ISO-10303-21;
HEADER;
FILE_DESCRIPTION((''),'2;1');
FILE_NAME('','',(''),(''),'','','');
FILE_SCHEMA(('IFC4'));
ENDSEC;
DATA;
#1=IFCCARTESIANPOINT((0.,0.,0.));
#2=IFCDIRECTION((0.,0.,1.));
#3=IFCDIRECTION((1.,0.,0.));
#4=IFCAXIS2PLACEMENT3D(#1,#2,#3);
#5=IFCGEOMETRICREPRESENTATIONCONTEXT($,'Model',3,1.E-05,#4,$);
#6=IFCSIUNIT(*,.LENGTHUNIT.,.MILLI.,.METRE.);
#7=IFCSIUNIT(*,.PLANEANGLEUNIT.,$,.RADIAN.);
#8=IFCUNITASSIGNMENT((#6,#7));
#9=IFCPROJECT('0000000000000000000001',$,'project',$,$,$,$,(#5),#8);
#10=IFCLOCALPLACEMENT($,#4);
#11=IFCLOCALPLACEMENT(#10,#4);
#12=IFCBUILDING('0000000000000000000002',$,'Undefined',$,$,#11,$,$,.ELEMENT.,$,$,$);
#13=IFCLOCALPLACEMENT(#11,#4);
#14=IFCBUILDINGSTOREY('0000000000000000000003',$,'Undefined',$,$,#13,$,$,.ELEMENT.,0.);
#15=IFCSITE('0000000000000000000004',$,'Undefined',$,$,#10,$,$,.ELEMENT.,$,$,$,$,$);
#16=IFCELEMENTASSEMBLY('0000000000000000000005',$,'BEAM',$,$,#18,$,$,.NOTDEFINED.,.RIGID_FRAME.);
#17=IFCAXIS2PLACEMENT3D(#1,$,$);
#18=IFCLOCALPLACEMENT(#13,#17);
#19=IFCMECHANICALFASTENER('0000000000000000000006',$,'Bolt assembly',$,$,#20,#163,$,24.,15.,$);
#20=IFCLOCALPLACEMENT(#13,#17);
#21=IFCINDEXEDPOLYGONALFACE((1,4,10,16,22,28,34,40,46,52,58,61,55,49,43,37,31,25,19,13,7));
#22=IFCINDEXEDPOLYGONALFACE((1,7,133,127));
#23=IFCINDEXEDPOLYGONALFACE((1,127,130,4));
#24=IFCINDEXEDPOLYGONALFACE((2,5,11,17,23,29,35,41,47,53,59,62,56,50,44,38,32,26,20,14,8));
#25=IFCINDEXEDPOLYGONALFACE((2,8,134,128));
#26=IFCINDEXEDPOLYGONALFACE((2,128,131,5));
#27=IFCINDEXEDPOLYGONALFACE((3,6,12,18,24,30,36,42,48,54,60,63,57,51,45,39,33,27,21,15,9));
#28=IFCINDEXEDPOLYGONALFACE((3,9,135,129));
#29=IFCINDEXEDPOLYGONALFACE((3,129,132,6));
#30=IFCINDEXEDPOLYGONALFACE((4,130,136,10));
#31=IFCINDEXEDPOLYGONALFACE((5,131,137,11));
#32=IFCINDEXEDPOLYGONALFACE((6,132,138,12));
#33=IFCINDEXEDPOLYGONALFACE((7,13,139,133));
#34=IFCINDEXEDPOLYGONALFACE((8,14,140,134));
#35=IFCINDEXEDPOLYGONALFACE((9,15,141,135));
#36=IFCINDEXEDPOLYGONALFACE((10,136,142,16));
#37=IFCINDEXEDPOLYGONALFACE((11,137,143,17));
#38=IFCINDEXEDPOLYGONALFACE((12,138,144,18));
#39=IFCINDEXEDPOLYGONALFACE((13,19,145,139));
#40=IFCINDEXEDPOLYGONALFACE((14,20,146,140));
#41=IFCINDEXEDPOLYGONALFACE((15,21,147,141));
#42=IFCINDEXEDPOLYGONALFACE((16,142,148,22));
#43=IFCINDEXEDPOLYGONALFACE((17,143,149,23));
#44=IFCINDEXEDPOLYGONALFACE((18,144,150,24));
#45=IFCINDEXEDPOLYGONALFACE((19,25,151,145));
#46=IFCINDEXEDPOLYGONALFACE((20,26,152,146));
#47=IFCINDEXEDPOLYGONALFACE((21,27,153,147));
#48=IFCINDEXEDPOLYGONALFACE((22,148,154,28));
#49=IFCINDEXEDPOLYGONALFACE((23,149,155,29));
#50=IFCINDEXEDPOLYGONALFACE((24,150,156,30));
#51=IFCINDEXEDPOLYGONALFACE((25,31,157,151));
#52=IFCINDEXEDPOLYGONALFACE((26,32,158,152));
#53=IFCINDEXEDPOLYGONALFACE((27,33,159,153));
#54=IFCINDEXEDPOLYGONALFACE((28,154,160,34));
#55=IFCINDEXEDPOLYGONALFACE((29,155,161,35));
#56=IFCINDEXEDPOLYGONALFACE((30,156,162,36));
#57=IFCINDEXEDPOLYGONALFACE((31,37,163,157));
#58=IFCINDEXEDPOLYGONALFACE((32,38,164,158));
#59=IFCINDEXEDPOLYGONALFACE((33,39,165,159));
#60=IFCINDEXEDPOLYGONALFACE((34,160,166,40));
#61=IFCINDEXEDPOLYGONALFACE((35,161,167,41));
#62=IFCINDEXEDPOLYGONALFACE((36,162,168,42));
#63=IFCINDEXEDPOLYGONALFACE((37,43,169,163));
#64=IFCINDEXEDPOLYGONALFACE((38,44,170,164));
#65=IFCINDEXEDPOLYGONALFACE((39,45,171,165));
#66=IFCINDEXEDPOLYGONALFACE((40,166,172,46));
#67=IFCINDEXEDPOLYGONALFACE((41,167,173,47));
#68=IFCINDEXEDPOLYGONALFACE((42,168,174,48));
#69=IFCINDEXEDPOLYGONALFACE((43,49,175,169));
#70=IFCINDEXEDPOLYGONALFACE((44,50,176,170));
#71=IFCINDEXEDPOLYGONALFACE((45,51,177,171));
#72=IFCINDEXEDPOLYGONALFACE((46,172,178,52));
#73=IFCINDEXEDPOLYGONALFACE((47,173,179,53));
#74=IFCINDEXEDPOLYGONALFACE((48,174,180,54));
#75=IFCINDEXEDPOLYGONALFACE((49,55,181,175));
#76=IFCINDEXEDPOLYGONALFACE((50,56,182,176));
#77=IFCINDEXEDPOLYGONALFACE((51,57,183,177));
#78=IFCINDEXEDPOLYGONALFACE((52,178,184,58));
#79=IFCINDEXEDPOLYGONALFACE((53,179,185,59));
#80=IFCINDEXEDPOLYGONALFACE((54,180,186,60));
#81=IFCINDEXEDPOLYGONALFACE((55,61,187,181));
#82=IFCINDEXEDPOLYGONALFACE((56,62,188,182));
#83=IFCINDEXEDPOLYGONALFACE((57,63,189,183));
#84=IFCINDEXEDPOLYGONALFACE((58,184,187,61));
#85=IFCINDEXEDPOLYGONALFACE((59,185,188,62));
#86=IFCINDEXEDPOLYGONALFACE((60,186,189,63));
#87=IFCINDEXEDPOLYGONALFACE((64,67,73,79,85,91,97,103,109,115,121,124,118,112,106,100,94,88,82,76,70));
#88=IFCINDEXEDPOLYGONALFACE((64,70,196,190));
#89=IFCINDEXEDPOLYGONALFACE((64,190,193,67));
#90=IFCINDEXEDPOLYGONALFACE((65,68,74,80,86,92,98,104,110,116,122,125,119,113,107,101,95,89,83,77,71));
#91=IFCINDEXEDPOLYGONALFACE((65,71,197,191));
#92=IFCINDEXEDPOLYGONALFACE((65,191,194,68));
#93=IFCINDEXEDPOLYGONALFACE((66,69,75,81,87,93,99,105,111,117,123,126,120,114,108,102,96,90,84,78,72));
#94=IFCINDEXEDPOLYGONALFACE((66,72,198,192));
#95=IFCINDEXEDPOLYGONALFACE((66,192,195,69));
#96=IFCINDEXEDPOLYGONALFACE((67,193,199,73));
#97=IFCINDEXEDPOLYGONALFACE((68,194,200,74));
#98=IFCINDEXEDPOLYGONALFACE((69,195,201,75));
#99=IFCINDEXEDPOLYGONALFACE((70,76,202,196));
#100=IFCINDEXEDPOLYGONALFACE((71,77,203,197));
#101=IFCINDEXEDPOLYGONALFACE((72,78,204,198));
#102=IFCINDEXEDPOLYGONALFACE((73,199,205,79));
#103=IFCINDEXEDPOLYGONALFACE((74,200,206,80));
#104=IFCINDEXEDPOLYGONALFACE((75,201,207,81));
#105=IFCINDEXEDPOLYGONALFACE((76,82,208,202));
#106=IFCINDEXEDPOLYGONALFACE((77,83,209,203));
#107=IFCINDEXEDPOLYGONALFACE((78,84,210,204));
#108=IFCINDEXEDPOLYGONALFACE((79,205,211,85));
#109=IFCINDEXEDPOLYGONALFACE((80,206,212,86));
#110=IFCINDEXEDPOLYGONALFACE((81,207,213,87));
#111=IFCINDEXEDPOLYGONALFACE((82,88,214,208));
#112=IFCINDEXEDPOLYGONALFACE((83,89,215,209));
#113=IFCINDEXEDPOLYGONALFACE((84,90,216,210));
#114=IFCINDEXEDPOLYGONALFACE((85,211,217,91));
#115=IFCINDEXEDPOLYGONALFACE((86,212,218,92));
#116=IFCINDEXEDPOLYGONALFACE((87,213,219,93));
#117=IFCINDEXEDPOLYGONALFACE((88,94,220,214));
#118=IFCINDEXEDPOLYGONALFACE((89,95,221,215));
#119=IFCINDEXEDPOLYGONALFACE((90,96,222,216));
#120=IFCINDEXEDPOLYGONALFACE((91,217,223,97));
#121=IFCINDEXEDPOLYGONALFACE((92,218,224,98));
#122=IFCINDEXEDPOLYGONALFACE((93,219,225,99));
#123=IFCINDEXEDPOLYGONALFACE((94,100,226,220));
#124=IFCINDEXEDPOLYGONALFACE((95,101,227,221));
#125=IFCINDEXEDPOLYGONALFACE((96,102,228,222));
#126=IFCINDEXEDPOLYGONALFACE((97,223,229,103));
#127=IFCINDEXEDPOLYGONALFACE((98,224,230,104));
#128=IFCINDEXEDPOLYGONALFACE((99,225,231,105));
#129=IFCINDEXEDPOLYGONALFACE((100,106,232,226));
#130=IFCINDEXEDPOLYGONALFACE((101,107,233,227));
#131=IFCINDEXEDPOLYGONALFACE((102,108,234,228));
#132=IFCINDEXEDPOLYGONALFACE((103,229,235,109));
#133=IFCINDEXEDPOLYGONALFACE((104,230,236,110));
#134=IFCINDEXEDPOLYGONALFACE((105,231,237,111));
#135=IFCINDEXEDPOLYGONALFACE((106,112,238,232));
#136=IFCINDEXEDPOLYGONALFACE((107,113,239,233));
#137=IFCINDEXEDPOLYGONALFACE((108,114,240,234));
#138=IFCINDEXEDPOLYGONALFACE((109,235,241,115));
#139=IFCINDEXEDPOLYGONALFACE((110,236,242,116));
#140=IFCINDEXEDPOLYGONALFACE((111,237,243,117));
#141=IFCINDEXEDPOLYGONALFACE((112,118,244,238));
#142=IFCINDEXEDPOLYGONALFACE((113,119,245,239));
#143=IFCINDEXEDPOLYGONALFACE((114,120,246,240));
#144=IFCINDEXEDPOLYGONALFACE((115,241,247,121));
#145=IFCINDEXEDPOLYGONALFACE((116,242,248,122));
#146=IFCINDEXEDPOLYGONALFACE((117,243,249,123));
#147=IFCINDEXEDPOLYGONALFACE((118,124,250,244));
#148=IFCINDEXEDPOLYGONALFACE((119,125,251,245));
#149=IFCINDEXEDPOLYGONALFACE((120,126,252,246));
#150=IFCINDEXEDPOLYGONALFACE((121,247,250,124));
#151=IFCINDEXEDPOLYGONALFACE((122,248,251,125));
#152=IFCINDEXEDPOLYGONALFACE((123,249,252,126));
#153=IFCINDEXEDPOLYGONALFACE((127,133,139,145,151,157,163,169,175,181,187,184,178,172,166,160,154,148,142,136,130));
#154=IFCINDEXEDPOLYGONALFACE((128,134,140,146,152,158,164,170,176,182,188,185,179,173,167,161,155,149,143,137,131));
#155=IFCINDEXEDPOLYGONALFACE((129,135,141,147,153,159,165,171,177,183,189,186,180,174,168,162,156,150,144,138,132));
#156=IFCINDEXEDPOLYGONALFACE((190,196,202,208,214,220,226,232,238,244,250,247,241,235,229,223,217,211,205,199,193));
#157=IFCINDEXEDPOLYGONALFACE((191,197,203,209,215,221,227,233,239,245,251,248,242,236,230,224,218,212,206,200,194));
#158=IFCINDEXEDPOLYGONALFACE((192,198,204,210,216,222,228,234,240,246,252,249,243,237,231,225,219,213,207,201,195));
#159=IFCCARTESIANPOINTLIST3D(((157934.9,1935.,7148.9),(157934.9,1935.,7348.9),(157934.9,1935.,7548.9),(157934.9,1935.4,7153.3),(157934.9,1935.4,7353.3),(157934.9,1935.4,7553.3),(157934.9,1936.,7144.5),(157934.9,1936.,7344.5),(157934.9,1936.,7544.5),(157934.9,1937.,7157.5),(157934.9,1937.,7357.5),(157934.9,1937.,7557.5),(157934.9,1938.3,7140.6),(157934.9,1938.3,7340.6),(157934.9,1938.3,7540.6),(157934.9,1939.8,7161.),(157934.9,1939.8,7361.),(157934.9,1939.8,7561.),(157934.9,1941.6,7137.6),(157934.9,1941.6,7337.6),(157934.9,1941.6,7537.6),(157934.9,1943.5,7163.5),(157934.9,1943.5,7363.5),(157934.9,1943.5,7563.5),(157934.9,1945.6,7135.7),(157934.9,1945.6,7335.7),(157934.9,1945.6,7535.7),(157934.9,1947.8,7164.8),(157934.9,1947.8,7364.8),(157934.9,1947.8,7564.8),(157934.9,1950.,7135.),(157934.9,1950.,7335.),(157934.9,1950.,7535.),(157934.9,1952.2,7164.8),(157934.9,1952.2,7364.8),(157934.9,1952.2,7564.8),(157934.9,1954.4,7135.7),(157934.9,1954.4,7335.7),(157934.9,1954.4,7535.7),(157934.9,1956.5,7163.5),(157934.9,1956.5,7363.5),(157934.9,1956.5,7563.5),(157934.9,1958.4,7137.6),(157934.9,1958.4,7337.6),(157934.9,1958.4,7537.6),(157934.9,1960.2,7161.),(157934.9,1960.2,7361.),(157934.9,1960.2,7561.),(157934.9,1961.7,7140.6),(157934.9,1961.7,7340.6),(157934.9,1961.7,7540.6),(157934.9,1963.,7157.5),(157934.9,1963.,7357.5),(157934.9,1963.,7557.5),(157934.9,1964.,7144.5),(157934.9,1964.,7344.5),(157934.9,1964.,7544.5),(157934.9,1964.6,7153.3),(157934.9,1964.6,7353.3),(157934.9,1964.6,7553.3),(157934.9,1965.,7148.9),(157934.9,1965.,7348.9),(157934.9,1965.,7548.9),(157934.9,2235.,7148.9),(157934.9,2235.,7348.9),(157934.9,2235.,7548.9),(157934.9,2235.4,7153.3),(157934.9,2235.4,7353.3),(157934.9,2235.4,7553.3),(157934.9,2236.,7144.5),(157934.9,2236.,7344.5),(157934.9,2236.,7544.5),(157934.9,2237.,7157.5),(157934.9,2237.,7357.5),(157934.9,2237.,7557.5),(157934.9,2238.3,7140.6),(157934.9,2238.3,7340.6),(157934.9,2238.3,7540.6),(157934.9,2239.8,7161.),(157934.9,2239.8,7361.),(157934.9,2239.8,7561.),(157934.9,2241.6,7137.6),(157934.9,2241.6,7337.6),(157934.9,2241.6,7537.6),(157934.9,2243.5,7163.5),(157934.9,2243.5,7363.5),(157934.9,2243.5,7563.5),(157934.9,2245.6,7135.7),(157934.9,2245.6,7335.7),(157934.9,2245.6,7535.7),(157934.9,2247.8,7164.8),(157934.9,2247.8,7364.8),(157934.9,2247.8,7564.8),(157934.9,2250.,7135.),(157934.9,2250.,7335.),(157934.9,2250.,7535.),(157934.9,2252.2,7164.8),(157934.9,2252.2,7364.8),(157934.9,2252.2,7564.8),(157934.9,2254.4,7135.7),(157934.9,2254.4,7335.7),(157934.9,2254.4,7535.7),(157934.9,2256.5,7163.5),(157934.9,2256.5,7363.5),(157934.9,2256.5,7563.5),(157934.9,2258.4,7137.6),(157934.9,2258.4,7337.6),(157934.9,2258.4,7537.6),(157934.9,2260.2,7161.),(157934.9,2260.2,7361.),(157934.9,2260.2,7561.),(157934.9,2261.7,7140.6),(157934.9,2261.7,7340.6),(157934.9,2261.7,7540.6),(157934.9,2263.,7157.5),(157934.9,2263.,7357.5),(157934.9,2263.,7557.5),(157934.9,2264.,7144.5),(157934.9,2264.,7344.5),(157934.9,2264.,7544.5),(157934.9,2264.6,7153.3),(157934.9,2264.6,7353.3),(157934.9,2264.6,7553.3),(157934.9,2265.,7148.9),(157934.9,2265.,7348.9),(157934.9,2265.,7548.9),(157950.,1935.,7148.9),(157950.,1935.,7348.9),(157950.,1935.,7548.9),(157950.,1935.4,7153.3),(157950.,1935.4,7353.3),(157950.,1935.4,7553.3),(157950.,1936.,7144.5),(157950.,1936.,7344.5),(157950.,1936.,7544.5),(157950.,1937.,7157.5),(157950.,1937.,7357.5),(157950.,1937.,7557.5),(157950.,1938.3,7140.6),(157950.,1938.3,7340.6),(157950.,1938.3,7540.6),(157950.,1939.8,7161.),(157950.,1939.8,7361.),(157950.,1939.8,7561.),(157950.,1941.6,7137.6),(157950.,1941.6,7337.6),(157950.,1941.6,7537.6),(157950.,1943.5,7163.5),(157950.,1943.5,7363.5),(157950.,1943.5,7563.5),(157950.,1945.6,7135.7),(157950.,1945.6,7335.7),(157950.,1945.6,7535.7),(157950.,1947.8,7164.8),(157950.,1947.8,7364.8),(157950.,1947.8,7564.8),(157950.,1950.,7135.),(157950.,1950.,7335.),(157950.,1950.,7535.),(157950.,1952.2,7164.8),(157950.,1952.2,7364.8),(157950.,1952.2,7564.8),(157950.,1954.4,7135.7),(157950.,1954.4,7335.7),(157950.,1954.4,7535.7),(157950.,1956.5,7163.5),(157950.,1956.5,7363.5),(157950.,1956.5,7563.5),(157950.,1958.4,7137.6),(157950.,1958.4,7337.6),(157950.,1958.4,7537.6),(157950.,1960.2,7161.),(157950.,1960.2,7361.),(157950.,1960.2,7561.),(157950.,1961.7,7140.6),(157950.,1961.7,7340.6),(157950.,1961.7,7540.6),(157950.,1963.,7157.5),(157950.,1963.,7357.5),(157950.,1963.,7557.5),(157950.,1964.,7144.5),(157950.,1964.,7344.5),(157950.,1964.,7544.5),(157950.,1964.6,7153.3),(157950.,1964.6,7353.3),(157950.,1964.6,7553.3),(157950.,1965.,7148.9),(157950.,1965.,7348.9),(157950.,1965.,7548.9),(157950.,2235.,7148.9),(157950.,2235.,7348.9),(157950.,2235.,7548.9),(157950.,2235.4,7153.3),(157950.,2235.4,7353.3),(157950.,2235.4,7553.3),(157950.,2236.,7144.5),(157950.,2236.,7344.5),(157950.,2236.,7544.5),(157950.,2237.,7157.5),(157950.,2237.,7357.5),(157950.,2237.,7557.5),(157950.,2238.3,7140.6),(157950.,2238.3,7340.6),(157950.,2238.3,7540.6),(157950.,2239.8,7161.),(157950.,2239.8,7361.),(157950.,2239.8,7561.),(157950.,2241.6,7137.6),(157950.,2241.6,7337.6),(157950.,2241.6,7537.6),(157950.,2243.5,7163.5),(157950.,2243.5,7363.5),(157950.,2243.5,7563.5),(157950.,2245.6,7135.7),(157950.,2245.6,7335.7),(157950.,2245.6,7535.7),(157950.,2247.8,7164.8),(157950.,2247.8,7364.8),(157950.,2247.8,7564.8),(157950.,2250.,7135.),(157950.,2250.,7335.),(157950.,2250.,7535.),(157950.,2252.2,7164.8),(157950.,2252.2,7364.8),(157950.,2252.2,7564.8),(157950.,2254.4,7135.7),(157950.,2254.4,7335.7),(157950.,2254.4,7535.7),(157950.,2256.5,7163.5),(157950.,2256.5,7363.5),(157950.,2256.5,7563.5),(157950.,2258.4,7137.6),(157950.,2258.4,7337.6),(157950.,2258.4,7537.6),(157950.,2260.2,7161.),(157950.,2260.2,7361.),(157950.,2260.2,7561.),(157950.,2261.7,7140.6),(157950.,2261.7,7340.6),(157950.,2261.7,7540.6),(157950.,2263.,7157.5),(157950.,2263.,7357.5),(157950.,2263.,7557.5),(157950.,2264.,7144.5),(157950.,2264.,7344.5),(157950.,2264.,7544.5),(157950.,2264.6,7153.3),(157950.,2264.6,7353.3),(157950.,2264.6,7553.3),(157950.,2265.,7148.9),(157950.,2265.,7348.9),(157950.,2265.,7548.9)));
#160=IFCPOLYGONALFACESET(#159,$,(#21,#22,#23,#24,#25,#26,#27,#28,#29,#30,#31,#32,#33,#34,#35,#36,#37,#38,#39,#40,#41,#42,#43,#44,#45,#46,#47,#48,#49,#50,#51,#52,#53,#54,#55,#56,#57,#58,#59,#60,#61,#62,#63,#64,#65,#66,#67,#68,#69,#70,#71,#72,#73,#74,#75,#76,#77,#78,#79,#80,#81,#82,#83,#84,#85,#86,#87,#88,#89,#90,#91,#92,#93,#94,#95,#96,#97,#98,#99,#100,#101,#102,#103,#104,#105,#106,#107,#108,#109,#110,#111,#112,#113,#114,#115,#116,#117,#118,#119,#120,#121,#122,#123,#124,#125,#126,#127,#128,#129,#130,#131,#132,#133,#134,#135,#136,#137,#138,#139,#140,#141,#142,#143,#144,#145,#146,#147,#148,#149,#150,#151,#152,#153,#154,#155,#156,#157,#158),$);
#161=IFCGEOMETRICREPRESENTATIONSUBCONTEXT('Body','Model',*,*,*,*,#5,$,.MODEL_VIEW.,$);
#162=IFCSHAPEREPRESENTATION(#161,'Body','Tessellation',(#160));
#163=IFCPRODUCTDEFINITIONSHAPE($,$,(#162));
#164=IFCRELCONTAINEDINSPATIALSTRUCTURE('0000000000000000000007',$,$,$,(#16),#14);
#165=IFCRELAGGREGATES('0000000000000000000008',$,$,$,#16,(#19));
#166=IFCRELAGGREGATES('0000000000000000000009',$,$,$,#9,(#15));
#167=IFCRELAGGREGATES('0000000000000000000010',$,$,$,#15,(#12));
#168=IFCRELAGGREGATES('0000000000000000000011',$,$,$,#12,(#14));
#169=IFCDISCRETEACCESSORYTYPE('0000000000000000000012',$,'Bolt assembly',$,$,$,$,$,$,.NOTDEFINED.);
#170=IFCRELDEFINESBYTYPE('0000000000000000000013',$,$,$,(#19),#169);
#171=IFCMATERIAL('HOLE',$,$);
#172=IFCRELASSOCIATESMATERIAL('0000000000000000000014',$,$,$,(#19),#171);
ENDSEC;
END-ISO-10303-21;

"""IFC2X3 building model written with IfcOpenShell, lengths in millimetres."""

from ifc_helpers import new_model, si_unit, frame, origin_with_axes, origin_2d_with_axis, place, context, subcontext, project, spatial, circle, extrude, source, transform, mapped, material, type_object, element, aggregate, save


model = new_model("IFC2X3")

# Units and contexts
model_context = context("Model", 3, precision=1e-05, world=origin_with_axes())
body_context = subcontext(model_context, "Body", "Model", "MODEL_VIEW")
ifc_project = project(units=[si_unit("LENGTHUNIT", "METRE", prefix="MILLI"), si_unit("PLANEANGLEUNIT", "RADIAN")], contexts=[model_context])

# Site, building, storey
site_placement = place(None, origin_with_axes())
site = spatial("IfcSite", under=ifc_project, at=site_placement, Name="Undefined", CompositionType="ELEMENT")
building_placement = place(site_placement, origin_with_axes())
building = spatial("IfcBuilding", under=site, at=building_placement, Name="Undefined", CompositionType="ELEMENT")
storey_placement = place(building_placement, origin_with_axes())
storey = spatial("IfcBuildingStorey", under=building, at=storey_placement, Name="Undefined", CompositionType="ELEMENT", Elevation=0.0)

# Element assembly
assembly_1_placement = place(storey_placement, origin_with_axes())
assembly_1 = element("IfcElementAssembly", 1, at=assembly_1_placement, inside=storey, Name="BEAM", AssemblyPlace="NOTDEFINED", PredefinedType="RIGID_FRAME")

# Mechanical fastener
ifc_material_1 = material(Name="HOLE")
discrete_accessory_type_1 = type_object("IfcDiscreteAccessoryType", Name="Bolt assembly")
shared_shape_1 = source(origin_with_axes(), body_context, "Body", "SweptSolid", [
    extrude(circle(Radius=15.0, at=origin_2d_with_axis()), frame((0.0, -15.0, 0.0), z_axis=(0.0, 1.0, 0.0), x_axis=(1.0, 0.0, 0.0)), (0.0, 0.0, 1.0), 15.1),
])
mechanical_fastener_1_placement = place(assembly_1_placement, frame((157935.0, 2100.0, 7550.0), z_axis=(0.0, 1.0, 0.0), x_axis=(0.0, 0.0, -1.0)))
mechanical_fastener_1 = element("IfcMechanicalFastener", 2, at=mechanical_fastener_1_placement, type_object=discrete_accessory_type_1, material=ifc_material_1, Name="Bolt assembly", NominalDiameter=24.0, NominalLength=15.0, context=body_context, shape_type="MappedRepresentation", body=[
    mapped(shared_shape_1, transform((0.0, 0.0, -150.0))),
    mapped(shared_shape_1, transform((0.0, 0.0, 150.0))),
    mapped(shared_shape_1, transform((200.0, 0.0, -150.0))),
    mapped(shared_shape_1, transform((200.0, 0.0, 150.0))),
    mapped(shared_shape_1, transform((400.0, 0.0, -150.0))),
    mapped(shared_shape_1, transform((400.0, 0.0, 150.0))),
])
aggregate(assembly_1, [mechanical_fastener_1])

save(model, "model.ifc")
